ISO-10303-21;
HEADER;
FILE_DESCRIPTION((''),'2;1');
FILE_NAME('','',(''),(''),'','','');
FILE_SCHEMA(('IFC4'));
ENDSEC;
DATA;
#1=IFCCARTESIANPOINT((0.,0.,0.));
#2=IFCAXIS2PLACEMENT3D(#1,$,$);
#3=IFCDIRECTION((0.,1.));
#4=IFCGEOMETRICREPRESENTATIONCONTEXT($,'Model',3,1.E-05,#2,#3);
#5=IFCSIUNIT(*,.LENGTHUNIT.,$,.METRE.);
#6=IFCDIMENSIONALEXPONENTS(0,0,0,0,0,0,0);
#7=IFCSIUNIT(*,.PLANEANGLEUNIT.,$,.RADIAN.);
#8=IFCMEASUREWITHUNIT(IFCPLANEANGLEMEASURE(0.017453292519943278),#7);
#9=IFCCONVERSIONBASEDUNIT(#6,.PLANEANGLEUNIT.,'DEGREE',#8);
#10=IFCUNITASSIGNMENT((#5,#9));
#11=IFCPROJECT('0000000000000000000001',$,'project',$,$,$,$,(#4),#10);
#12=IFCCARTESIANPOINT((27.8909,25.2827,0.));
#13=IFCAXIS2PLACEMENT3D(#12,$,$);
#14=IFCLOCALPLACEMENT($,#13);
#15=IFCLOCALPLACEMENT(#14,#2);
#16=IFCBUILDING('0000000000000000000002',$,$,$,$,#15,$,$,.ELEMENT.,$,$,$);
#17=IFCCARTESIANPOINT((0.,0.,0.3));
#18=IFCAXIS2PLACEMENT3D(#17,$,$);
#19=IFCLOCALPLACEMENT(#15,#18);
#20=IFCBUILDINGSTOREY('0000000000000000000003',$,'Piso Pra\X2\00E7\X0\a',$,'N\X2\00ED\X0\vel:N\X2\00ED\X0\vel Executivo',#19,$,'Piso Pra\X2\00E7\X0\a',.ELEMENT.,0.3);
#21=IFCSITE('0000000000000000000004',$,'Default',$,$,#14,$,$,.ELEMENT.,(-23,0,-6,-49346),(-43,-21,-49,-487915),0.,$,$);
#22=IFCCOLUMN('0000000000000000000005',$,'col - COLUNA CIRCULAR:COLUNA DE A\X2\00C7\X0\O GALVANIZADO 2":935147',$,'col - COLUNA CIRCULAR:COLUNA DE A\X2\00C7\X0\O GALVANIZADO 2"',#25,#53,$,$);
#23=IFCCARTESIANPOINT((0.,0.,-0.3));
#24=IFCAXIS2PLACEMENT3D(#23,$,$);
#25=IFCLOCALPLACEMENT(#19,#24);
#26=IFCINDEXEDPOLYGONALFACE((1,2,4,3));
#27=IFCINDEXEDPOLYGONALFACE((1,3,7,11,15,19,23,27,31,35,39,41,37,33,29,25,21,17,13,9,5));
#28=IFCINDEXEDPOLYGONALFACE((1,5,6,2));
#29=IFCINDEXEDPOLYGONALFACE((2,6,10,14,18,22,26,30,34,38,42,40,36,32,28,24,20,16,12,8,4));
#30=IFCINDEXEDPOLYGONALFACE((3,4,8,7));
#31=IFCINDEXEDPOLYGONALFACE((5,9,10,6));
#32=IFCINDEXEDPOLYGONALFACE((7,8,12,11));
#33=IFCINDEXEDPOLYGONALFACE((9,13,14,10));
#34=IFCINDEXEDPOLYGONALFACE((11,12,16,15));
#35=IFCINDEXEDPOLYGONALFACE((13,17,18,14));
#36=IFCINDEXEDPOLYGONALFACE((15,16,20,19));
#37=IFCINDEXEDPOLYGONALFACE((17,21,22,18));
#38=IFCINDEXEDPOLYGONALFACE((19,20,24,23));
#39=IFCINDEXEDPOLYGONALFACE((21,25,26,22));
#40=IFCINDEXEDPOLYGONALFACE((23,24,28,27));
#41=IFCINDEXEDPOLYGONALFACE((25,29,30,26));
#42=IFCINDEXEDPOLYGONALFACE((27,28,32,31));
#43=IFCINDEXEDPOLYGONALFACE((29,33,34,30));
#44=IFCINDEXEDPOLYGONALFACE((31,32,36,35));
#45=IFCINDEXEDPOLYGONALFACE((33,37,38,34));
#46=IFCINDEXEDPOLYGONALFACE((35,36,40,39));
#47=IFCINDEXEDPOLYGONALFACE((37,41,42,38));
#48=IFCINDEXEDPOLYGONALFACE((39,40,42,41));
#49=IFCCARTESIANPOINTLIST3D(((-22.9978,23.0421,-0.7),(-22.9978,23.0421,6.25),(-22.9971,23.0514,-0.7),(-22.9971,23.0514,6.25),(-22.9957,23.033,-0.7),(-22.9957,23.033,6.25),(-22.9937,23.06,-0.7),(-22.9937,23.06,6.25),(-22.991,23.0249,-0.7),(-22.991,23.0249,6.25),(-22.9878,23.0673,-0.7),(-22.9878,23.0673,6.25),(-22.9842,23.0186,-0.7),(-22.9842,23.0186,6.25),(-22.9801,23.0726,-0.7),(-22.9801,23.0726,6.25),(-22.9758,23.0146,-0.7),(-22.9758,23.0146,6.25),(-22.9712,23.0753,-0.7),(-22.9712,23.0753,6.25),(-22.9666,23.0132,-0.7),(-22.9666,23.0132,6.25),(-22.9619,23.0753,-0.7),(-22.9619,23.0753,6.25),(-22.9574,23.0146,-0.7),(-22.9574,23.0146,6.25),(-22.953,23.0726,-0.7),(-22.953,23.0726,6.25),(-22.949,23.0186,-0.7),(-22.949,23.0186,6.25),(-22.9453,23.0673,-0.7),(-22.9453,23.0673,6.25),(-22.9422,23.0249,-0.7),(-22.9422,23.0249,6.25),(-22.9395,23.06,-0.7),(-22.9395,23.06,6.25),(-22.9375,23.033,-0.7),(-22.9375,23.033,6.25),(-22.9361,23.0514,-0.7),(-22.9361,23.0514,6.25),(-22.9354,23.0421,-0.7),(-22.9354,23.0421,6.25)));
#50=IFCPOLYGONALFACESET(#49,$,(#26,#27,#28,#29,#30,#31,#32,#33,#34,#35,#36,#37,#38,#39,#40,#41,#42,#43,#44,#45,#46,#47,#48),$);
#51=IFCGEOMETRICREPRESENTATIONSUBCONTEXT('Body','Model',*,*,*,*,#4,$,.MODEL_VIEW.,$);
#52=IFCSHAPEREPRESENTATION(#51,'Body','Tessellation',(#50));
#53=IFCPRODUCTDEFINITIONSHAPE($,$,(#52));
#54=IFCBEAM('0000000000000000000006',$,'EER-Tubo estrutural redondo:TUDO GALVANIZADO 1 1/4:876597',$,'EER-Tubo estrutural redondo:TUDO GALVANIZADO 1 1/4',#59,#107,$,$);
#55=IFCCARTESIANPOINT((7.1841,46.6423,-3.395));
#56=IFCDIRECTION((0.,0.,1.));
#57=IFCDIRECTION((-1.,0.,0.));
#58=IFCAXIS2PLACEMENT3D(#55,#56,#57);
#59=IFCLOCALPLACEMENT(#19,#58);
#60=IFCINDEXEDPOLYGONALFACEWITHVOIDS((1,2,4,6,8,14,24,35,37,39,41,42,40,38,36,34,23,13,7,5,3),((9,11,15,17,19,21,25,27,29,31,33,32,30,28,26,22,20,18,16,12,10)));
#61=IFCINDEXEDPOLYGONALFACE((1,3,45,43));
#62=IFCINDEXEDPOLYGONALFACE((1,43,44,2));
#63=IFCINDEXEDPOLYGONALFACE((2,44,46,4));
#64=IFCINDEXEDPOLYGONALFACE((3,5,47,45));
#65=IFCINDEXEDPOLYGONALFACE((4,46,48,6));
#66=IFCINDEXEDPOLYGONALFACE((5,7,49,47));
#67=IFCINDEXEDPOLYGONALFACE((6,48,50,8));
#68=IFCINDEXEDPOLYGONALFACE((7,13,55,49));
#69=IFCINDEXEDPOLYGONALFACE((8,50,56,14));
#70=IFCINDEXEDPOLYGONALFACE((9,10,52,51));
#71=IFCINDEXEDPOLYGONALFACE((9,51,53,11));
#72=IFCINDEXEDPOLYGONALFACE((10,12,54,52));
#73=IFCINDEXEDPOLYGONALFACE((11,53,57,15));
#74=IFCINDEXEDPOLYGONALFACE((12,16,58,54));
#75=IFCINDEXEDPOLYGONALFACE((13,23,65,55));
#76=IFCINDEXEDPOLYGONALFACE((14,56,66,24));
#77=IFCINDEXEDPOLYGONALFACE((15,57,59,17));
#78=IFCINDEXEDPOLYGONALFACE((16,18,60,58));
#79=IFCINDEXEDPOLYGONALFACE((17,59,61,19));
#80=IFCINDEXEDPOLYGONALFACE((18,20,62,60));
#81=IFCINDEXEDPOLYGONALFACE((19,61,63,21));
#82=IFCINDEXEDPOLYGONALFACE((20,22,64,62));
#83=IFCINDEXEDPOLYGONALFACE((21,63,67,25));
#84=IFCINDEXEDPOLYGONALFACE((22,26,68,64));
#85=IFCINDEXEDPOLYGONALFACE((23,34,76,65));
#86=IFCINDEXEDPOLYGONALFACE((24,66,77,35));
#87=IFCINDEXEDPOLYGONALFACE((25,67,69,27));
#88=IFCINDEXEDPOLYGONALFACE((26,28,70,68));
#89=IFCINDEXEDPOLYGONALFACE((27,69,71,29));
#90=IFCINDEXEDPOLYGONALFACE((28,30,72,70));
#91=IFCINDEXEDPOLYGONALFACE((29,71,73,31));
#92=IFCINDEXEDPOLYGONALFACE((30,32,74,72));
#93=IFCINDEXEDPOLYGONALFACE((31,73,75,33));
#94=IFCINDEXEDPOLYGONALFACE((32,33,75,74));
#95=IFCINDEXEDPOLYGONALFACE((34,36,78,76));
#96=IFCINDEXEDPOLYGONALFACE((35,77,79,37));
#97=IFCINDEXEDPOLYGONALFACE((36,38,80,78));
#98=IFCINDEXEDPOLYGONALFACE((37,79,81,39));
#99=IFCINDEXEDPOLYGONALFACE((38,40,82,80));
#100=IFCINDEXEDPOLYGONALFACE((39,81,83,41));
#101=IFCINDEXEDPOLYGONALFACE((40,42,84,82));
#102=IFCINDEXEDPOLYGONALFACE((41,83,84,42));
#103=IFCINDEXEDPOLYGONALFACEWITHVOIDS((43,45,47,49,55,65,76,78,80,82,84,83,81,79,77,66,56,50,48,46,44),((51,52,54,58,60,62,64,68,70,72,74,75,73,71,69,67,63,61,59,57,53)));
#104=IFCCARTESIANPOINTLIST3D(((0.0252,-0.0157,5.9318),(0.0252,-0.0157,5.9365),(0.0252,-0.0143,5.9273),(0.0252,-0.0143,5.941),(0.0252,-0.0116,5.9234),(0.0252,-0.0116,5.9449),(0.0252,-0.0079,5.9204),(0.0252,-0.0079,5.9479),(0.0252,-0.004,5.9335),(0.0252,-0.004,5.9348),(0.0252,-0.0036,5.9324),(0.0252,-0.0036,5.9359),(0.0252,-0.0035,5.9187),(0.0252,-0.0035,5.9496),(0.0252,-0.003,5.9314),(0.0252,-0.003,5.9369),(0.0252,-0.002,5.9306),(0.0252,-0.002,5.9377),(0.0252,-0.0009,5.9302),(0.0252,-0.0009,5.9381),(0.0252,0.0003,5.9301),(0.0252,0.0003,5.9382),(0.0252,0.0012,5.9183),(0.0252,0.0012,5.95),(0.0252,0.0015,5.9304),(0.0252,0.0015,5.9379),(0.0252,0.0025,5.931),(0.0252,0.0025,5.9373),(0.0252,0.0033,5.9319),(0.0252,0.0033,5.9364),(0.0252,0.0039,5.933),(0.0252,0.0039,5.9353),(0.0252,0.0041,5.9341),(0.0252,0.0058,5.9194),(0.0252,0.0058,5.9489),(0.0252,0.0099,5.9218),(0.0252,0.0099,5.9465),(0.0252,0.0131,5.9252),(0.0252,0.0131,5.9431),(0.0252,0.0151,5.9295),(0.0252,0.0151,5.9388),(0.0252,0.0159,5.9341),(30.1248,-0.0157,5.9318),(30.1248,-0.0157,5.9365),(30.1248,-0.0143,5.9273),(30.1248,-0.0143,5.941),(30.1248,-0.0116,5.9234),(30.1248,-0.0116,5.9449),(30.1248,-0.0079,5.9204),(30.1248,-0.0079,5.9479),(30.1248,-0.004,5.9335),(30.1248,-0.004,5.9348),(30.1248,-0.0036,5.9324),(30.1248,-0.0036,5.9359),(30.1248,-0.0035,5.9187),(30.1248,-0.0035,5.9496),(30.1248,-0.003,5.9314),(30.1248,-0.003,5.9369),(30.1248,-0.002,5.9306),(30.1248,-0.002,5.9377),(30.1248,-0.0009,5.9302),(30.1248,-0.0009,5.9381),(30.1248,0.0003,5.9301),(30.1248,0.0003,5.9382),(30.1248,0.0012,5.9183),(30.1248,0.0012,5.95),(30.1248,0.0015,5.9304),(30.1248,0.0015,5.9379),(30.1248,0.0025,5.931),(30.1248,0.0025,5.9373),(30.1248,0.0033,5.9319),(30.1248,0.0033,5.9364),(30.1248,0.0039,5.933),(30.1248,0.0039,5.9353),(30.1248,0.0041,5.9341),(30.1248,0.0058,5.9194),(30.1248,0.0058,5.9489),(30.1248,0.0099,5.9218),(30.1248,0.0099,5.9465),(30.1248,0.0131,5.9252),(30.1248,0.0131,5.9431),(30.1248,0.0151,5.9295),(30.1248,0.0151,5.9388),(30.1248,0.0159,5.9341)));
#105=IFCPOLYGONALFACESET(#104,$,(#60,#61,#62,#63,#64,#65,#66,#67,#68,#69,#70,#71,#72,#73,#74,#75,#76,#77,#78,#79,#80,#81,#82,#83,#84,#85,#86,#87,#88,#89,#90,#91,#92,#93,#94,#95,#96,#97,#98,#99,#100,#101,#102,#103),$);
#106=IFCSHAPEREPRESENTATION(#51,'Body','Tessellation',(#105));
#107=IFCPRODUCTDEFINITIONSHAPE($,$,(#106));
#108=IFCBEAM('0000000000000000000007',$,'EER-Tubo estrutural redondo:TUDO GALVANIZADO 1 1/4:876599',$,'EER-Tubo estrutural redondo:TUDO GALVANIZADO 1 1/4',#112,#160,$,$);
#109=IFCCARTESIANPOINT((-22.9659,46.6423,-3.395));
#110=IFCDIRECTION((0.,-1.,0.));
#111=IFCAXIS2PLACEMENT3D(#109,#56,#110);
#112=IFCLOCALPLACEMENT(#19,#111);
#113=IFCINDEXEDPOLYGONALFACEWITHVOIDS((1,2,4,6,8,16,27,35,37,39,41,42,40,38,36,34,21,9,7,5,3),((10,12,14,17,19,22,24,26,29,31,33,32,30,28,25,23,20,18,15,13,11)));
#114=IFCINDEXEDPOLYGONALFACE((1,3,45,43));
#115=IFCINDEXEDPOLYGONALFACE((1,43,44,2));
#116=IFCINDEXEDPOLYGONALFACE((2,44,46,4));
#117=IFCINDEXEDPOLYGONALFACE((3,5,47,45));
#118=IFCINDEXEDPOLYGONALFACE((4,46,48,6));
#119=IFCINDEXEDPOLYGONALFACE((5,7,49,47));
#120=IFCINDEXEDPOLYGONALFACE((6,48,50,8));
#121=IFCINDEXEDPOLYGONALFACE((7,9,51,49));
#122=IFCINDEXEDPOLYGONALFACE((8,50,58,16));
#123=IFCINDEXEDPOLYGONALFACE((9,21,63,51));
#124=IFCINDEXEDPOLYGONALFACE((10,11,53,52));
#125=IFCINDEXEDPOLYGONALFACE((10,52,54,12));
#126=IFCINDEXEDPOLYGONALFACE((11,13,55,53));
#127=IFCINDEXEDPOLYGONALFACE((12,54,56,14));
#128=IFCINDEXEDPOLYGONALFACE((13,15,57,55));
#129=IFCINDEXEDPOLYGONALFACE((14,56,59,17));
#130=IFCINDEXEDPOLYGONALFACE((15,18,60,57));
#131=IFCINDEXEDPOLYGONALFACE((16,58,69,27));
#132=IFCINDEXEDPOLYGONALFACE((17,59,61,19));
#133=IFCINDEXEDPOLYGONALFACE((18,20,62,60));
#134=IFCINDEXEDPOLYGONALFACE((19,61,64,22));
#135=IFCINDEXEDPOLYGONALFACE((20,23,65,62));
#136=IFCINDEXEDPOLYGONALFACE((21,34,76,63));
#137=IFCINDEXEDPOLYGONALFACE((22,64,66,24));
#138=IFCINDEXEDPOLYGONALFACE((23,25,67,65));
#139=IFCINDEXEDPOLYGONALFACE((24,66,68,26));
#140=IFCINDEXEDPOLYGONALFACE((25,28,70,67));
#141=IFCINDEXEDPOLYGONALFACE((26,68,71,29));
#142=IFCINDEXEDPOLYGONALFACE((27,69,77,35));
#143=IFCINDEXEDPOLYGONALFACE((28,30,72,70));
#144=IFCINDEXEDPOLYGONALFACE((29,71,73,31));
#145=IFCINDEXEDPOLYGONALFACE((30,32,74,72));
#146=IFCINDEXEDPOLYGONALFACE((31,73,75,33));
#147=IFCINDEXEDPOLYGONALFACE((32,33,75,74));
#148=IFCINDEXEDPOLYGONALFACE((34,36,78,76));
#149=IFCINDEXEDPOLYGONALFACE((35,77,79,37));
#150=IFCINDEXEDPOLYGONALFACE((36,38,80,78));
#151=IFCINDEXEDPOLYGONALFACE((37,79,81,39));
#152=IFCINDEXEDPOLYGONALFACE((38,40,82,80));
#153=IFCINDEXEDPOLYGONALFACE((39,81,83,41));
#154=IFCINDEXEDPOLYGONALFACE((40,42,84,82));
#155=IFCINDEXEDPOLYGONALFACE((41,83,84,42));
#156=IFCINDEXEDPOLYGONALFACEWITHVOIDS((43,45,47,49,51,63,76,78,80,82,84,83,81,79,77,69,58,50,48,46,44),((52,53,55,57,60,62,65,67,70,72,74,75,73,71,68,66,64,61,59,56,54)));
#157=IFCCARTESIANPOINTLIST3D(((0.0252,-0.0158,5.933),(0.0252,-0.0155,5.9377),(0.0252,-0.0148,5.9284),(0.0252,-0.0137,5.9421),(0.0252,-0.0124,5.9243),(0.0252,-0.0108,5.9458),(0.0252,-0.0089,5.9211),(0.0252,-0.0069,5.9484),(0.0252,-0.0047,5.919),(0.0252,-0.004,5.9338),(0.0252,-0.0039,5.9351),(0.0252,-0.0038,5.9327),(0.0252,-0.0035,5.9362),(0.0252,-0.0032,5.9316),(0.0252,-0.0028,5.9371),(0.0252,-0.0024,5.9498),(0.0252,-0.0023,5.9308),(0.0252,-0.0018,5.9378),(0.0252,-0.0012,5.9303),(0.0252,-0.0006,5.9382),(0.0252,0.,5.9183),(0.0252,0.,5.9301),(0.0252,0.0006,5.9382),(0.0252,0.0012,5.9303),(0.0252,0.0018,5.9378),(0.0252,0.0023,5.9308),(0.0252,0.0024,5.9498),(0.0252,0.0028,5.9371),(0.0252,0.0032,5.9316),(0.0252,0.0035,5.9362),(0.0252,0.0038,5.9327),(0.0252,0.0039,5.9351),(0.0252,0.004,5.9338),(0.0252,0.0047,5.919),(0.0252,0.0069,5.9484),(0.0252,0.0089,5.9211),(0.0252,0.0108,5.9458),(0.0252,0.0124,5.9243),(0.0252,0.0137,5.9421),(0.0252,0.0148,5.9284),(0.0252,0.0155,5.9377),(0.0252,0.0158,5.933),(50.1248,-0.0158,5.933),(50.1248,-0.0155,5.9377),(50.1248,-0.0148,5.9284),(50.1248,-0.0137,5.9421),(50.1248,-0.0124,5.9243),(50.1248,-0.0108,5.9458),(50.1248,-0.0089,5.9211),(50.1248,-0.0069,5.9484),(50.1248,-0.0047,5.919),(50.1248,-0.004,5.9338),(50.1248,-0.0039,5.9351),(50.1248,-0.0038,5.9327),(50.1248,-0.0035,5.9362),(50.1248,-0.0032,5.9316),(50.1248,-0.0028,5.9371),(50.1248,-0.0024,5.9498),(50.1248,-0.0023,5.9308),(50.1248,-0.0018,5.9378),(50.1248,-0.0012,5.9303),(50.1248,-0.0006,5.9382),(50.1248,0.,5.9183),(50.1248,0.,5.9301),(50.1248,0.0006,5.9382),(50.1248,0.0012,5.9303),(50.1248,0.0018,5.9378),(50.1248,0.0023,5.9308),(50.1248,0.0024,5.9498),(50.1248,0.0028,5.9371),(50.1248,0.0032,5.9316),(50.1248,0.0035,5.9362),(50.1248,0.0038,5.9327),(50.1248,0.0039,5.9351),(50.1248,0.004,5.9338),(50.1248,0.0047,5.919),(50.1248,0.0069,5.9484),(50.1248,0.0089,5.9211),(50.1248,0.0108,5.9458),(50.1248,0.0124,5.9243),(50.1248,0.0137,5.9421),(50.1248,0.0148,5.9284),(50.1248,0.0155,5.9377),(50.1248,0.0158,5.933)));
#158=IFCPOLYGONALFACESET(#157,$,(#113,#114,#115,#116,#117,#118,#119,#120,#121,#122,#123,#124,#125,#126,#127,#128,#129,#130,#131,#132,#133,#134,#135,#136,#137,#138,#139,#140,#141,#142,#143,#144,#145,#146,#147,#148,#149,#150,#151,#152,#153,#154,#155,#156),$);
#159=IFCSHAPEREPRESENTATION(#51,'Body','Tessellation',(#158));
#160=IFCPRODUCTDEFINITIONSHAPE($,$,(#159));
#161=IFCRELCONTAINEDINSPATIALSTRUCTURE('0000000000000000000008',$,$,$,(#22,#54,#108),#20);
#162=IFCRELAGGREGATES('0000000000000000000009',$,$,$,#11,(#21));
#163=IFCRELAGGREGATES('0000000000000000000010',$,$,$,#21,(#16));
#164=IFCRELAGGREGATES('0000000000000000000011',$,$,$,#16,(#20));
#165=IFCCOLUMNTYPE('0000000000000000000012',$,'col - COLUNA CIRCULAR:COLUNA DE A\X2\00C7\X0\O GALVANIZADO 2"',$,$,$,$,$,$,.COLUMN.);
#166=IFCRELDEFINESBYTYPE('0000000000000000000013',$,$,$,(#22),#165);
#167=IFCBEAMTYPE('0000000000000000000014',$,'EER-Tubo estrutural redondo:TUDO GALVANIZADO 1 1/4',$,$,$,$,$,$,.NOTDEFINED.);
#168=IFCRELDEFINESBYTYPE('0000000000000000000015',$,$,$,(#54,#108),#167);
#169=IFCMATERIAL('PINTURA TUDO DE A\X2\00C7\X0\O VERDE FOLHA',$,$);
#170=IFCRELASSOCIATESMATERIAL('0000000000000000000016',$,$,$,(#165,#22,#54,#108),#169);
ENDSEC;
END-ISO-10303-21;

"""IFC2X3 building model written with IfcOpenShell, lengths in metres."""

from ifc_helpers import new_model, entity, si_unit, converted_unit, direction, frame, origin, origin_2d_with_axis, place, context, subcontext, project, spatial, circle, hollow_circle, extrude, source, transform, mapped, material, type_object, type_shapes, element, save


model = new_model("IFC2X3")

# Units and contexts
model_context = context("Model", 3, precision=1e-05, world=origin(), true_north=direction((0.0, 1.0)))
body_context = subcontext(model_context, "Body", "Model", "MODEL_VIEW")
ifc_project = project(units=[si_unit("LENGTHUNIT", "METRE"), converted_unit("PLANEANGLEUNIT", "DEGREE", entity("IfcPlaneAngleMeasure", 0.017453292519943278), si_unit("PLANEANGLEUNIT", "RADIAN"), dimensions=[0, 0, 0, 0, 0, 0, 0])], contexts=[model_context])

# Site, building, storey
site_placement = place(None, frame((27.8909, 25.2827, 0.0)))
site = spatial("IfcSite", under=ifc_project, at=site_placement, Name="Default", CompositionType="ELEMENT", RefLatitude=(-23, 0, -6, -49346), RefLongitude=(-43, -21, -49, -487915), RefElevation=0.0)
building_placement = place(site_placement, origin())
building = spatial("IfcBuilding", under=site, at=building_placement, CompositionType="ELEMENT")
storey_placement = place(building_placement, frame((0.0, 0.0, 0.3)))
storey = spatial("IfcBuildingStorey", under=building, at=storey_placement, Name="Piso Praça", ObjectType="Nível:Nível Executivo", LongName="Piso Praça", CompositionType="ELEMENT", Elevation=0.3)

# Column
ifc_material_1 = material(Name="PINTURA TUDO DE AÇO VERDE FOLHA")
column_type_1 = type_object("IfcColumnType", Name="col - COLUNA CIRCULAR:COLUNA DE AÇO GALVANIZADO 2\"", PredefinedType="COLUMN", material=ifc_material_1)
shared_shape_1 = source(origin(), body_context, "Body", "SweptSolid", [
    extrude(circle(Radius=0.0312, at=origin_2d_with_axis()), frame((-22.9666, 23.0444, -0.7), z_axis=(0.0, 0.0, 1.0), x_axis=(0.0, -1.0, 0.0)), (0.0, 0.0, 1.0), 6.95),
])
type_shapes(column_type_1, [shared_shape_1])
column_1_placement = place(storey_placement, frame((0.0, 0.0, -0.3)))
element("IfcColumn", 1, at=column_1_placement, inside=storey, type_object=column_type_1, material=ifc_material_1, Name="col - COLUNA CIRCULAR:COLUNA DE AÇO GALVANIZADO 2\":935147", ObjectType="col - COLUNA CIRCULAR:COLUNA DE AÇO GALVANIZADO 2\"", context=body_context, shape_type="MappedRepresentation", body=[
    mapped(shared_shape_1, transform((0.0, 0.0, 0.0), scale=1.0)),
])

# Beams
beam_type_1 = type_object("IfcBeamType", Name="EER-Tubo estrutural redondo:TUDO GALVANIZADO 1 1/4", PredefinedType="NOTDEFINED")
beam_1_placement = place(storey_placement, frame((7.1841, 46.6423, -3.395), z_axis=(0.0, 0.0, 1.0), x_axis=(-1.0, 0.0, 0.0)))
element("IfcBeam", 2, at=beam_1_placement, inside=storey, type_object=beam_type_1, material=ifc_material_1, Name="EER-Tubo estrutural redondo:TUDO GALVANIZADO 1 1/4:876597", ObjectType="EER-Tubo estrutural redondo:TUDO GALVANIZADO 1 1/4", context=body_context, shape_type="SweptSolid", body=[
    extrude(hollow_circle(Radius=0.0159, WallThickness=0.0118, at=origin_2d_with_axis()), frame((0.0252, 0.0, 5.9341), z_axis=(1.0, 0.0, 0.0), x_axis=(0.0, 1.0, 0.0)), (0.0, 0.0, 1.0), 30.0996),
])
beam_2_placement = place(storey_placement, frame((-22.9659, 46.6423, -3.395), z_axis=(0.0, 0.0, 1.0), x_axis=(0.0, -1.0, 0.0)))
element("IfcBeam", 3, at=beam_2_placement, inside=storey, type_object=beam_type_1, material=ifc_material_1, Name="EER-Tubo estrutural redondo:TUDO GALVANIZADO 1 1/4:876599", ObjectType="EER-Tubo estrutural redondo:TUDO GALVANIZADO 1 1/4", context=body_context, shape_type="SweptSolid", body=[
    extrude(hollow_circle(Radius=0.0159, WallThickness=0.0118, at=origin_2d_with_axis()), frame((0.0252, 0.0, 5.9341), z_axis=(1.0, 0.0, 0.0), x_axis=(0.0, 0.0, -1.0)), (0.0, 0.0, 1.0), 50.0996),
])

save(model, "model.ifc")
